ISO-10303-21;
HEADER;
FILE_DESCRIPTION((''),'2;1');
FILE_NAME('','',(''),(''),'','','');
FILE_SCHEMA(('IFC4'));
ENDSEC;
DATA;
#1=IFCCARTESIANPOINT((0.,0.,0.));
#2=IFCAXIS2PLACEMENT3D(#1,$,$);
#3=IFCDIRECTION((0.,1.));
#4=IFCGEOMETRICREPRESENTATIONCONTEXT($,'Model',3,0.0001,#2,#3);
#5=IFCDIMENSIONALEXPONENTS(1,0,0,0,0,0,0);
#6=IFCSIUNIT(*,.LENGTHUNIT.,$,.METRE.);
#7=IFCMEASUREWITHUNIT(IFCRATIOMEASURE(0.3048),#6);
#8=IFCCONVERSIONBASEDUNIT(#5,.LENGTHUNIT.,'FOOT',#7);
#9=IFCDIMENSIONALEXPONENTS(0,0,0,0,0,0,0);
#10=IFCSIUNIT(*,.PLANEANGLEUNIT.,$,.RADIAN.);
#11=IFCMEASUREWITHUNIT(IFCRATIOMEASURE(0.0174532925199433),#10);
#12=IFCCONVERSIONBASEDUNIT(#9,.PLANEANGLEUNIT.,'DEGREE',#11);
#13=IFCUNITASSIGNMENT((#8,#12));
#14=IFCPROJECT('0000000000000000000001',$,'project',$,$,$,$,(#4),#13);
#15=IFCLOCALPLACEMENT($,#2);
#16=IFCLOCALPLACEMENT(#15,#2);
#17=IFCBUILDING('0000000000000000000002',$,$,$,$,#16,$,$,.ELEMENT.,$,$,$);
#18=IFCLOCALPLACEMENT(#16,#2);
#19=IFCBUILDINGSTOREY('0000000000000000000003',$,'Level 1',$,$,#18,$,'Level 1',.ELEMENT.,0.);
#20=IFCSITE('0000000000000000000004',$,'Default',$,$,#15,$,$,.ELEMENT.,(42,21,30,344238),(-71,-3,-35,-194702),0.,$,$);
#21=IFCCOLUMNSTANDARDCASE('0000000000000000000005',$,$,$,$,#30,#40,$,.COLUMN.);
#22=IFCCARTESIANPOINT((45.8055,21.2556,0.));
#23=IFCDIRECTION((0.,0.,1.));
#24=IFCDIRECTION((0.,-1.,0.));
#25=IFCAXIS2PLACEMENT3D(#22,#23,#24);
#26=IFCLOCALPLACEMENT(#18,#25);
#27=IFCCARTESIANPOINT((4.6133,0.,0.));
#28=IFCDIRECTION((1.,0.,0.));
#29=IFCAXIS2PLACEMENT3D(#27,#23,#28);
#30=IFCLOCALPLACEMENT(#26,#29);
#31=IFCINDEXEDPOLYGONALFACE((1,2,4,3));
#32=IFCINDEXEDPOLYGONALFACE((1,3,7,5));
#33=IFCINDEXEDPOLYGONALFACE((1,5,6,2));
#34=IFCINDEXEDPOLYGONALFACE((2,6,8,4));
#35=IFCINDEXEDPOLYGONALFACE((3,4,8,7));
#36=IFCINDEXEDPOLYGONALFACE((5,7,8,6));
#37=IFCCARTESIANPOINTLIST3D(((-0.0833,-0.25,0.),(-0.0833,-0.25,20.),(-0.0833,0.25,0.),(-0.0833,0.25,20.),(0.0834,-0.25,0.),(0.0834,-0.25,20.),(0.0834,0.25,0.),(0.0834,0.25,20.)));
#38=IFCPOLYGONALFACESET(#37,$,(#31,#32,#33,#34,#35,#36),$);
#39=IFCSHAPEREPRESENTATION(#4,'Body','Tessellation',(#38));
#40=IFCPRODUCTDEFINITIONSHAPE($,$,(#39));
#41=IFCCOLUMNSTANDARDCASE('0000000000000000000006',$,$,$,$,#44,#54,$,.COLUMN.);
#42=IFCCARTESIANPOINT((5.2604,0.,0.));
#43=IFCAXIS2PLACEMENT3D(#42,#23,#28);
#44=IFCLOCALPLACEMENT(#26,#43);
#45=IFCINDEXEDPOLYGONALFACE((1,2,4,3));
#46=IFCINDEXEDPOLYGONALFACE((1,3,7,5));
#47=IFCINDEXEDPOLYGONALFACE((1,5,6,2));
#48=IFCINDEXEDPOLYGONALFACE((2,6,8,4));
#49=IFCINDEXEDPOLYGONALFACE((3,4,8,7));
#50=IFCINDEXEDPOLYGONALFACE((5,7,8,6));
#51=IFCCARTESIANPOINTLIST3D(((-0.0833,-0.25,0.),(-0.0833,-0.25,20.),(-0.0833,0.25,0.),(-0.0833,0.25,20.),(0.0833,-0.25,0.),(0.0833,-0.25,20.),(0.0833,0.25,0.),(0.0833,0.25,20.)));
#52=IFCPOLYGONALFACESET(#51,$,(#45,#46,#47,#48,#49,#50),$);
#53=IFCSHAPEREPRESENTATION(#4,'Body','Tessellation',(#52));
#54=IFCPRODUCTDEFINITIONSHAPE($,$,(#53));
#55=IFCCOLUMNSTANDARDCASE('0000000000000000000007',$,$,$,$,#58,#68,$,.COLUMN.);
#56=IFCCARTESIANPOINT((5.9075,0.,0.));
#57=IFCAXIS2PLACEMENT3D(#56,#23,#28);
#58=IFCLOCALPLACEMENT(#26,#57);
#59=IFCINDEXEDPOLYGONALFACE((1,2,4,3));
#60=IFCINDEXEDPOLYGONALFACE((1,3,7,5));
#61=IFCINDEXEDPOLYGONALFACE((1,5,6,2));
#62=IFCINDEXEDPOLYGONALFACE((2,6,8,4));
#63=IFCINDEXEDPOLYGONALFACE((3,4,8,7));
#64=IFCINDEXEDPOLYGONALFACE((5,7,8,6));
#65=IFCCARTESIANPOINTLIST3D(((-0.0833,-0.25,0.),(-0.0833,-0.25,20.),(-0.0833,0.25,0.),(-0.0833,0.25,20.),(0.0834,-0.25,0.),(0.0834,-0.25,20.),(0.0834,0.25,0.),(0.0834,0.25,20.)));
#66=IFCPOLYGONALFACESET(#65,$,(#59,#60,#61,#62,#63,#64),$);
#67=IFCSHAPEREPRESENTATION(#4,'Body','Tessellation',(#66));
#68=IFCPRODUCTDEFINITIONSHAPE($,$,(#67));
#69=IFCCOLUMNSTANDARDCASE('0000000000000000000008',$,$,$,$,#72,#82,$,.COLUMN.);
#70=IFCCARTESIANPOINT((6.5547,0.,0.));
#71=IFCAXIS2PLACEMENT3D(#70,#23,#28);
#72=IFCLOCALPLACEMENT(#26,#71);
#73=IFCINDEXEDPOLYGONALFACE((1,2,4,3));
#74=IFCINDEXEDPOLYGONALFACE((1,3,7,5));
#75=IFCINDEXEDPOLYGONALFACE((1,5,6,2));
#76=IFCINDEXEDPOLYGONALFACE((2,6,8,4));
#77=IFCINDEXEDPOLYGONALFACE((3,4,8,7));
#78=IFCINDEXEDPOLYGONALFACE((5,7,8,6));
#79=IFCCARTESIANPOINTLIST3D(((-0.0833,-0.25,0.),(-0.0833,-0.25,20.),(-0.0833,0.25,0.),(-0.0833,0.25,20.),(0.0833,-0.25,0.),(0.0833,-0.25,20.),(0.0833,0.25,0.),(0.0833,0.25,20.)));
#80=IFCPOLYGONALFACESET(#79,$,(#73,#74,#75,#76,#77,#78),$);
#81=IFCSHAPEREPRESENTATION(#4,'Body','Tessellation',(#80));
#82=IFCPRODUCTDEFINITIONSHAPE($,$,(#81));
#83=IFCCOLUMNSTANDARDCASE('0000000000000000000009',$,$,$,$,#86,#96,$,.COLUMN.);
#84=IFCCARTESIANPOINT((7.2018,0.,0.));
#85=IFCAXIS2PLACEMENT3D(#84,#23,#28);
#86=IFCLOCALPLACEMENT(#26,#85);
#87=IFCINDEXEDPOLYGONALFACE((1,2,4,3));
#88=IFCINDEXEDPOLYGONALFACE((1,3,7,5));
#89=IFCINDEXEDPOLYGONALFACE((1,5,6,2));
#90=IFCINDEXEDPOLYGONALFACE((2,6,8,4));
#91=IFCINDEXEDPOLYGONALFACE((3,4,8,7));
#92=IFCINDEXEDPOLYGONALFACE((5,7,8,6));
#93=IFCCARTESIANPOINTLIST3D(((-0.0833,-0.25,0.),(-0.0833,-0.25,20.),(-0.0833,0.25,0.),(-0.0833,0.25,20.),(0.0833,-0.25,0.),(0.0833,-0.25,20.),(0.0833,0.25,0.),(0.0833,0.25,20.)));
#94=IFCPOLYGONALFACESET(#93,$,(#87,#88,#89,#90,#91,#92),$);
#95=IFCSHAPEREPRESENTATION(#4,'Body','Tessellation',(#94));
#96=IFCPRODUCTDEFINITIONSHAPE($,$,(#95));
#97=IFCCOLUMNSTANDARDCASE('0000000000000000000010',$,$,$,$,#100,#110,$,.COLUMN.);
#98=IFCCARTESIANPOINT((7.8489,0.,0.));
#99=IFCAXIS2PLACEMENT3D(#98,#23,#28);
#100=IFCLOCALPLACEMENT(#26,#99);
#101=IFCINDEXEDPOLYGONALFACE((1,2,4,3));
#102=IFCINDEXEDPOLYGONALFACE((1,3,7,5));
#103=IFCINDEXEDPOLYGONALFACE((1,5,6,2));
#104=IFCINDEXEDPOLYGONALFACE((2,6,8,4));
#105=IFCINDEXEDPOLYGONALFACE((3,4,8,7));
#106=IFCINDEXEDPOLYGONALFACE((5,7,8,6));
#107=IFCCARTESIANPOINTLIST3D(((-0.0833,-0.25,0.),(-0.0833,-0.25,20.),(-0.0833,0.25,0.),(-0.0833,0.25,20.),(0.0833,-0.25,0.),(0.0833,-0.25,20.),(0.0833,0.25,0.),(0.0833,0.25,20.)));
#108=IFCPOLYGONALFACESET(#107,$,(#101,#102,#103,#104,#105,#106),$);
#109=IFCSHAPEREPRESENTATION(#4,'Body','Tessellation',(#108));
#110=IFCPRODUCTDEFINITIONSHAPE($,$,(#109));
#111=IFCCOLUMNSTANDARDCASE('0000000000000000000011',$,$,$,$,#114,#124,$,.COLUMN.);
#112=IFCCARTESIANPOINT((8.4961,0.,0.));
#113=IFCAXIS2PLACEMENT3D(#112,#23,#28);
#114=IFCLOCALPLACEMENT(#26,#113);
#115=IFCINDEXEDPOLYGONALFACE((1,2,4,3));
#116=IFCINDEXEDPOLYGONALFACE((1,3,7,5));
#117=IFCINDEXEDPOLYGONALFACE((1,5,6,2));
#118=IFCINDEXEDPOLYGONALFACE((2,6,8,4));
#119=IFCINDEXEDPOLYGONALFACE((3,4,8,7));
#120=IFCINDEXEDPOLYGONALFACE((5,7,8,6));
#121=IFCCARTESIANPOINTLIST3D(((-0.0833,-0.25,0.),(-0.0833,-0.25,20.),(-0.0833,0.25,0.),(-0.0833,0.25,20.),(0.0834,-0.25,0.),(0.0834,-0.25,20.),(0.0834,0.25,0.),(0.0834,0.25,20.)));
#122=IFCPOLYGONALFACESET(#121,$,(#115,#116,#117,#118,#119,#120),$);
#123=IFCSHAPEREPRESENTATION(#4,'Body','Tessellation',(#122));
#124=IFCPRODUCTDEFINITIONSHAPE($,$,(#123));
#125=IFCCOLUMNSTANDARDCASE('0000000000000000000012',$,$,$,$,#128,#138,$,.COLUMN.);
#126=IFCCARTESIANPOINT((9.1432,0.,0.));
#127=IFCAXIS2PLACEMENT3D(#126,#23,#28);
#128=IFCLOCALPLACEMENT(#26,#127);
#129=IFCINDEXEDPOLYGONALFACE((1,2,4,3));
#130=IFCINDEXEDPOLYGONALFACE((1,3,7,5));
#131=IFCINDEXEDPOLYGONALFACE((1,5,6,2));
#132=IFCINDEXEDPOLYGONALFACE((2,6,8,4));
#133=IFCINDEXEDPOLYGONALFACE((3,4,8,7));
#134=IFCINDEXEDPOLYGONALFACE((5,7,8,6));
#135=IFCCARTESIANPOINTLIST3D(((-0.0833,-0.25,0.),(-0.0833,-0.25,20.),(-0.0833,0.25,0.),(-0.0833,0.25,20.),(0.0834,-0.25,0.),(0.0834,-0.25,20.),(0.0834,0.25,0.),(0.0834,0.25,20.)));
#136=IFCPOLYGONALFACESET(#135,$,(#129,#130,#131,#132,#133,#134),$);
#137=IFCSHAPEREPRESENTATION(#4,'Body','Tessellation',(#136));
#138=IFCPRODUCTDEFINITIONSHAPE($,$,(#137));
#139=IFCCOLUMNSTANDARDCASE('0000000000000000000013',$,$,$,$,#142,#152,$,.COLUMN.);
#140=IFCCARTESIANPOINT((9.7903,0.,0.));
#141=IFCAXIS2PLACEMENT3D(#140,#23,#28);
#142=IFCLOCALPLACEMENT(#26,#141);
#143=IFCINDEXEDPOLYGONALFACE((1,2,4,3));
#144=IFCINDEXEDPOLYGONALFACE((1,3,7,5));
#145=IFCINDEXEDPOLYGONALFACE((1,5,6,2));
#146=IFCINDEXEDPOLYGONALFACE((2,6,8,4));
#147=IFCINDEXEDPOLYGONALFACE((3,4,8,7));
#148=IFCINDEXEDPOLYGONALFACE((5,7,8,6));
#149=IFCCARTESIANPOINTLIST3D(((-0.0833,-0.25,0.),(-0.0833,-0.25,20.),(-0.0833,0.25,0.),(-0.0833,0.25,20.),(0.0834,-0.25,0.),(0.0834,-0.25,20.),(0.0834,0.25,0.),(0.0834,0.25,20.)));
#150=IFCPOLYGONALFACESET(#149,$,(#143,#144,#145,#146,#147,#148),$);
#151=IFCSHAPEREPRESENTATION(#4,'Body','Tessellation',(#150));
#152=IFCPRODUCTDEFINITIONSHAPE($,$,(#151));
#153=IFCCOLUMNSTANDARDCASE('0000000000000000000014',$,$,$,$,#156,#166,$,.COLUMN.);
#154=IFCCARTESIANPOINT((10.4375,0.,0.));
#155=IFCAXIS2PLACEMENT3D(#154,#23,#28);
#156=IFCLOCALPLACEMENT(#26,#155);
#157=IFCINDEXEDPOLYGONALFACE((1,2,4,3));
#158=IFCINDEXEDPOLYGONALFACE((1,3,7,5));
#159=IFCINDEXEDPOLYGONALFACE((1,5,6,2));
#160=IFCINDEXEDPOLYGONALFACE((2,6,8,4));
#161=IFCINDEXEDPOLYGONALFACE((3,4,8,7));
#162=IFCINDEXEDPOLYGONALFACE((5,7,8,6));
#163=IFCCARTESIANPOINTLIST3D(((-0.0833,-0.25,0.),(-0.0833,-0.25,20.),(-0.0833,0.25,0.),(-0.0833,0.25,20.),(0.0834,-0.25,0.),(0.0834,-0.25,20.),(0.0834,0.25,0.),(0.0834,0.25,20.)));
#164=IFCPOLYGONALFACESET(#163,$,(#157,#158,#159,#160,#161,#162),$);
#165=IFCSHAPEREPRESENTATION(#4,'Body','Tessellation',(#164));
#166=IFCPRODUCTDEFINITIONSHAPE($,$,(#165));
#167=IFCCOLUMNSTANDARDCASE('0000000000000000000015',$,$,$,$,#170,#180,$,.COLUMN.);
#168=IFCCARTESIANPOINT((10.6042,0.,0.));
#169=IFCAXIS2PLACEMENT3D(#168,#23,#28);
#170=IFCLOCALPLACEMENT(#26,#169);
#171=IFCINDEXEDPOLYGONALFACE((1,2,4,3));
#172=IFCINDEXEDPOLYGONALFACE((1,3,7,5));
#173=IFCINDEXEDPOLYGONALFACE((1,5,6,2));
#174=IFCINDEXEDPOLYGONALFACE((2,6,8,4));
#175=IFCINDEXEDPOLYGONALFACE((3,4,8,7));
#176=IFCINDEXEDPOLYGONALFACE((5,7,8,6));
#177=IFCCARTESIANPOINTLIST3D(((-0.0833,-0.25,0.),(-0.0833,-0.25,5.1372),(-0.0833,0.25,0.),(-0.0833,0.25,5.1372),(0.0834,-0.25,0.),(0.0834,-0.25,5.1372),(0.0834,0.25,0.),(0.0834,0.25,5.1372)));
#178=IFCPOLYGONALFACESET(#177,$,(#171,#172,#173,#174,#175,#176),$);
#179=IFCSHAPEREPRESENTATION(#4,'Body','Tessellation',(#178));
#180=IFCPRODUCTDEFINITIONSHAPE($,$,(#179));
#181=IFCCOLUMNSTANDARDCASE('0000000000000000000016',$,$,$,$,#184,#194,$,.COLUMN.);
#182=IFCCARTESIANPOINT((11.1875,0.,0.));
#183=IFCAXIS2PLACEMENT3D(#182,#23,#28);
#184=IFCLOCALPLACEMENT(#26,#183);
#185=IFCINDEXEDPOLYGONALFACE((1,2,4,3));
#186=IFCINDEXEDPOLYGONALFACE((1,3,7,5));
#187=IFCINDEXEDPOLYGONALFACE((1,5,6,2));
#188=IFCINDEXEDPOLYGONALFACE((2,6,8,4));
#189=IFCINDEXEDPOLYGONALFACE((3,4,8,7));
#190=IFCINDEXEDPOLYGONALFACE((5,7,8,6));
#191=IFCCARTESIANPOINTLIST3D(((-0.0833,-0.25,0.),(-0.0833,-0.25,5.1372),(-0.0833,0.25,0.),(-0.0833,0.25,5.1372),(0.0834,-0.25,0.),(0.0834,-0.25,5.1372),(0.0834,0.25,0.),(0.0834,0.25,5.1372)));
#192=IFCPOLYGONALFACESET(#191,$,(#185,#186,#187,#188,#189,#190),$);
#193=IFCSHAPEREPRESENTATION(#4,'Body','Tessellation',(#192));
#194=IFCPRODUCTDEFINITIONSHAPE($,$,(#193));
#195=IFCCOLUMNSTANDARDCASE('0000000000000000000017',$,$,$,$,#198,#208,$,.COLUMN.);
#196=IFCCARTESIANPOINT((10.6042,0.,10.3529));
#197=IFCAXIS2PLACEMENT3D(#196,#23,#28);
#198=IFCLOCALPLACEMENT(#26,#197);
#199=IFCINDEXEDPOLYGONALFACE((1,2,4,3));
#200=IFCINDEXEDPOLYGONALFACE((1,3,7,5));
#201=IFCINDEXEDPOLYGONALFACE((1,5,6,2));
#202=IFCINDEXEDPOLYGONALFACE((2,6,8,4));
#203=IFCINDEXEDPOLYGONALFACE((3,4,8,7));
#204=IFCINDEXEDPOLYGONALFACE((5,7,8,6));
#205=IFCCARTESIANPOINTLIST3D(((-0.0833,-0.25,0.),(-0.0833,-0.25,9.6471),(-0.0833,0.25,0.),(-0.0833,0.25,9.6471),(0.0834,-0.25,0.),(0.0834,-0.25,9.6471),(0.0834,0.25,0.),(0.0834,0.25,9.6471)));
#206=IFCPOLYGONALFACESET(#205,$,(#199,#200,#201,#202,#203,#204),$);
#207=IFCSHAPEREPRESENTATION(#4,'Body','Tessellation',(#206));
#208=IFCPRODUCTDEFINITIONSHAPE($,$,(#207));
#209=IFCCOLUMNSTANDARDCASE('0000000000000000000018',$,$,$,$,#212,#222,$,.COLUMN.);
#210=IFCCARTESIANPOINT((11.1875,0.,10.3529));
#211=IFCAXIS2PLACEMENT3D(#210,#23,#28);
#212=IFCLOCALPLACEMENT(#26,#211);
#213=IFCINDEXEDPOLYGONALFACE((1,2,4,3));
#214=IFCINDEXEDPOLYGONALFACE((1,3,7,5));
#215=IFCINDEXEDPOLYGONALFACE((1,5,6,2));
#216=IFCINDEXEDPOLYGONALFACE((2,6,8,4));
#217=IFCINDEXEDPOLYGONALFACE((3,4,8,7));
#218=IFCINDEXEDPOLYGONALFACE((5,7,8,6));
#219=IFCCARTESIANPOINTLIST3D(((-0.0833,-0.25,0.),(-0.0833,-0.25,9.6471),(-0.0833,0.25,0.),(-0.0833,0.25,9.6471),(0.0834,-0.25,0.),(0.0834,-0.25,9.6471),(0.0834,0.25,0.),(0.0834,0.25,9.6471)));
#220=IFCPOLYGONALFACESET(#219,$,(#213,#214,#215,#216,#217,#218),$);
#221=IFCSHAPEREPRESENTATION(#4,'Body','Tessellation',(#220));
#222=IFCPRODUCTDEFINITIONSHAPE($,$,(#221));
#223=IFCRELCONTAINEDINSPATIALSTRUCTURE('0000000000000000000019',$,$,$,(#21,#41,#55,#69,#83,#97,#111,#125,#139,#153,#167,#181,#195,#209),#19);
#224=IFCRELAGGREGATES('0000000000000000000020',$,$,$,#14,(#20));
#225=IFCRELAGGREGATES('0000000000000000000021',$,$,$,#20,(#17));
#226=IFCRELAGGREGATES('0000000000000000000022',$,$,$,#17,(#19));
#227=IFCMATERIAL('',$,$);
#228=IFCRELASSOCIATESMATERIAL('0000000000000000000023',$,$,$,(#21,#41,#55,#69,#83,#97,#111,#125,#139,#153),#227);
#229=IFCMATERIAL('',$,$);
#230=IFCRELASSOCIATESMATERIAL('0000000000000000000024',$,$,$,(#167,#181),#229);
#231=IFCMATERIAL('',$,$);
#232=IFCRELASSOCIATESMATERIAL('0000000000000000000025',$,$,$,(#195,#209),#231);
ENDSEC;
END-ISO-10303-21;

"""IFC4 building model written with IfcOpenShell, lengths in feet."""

from ifc_helpers import new_model, entity, si_unit, converted_unit, direction, frame, origin, place, context, project, spatial, rectangle, extrude, material, element, save


model = new_model("IFC4")

# Units and contexts
model_context = context("Model", 3, precision=0.0001, world=origin(), true_north=direction((0.0, 1.0)))
ifc_project = project(units=[converted_unit("LENGTHUNIT", "FOOT", entity("IfcRatioMeasure", 0.3048), si_unit("LENGTHUNIT", "METRE"), dimensions=[1, 0, 0, 0, 0, 0, 0]), converted_unit("PLANEANGLEUNIT", "DEGREE", entity("IfcRatioMeasure", 0.0174532925199433), si_unit("PLANEANGLEUNIT", "RADIAN"), dimensions=[0, 0, 0, 0, 0, 0, 0])], contexts=[model_context])

# Site, building, storey
site_placement = place(None, origin())
site = spatial("IfcSite", under=ifc_project, at=site_placement, Name="Default", CompositionType="ELEMENT", RefLatitude=(42, 21, 30, 344238), RefLongitude=(-71, -3, -35, -194702), RefElevation=0.0)
building_placement = place(site_placement, origin())
building = spatial("IfcBuilding", under=site, at=building_placement, CompositionType="ELEMENT")
storey_placement = place(building_placement, origin())
storey = spatial("IfcBuildingStorey", under=building, at=storey_placement, Name="Level 1", LongName="Level 1", CompositionType="ELEMENT", Elevation=0.0)

# Columns
ifc_material_1 = material(Name="")
placement = place(storey_placement, frame((45.8055, 21.2556, 0.0), z_axis=(0.0, 0.0, 1.0), x_axis=(0.0, -1.0, 0.0)))
for number, where, z_axis, x_axis in (
    (1, (4.6133, 0.0, 0.0), (0.0, 0.0, 1.0), (1.0, 0.0, 0.0)),
    (2, (5.2604, 0.0, 0.0), (0.0, 0.0, 1.0), (1.0, 0.0, 0.0)),
    (3, (5.9075, 0.0, 0.0), (0.0, 0.0, 1.0), (1.0, 0.0, 0.0)),
    (4, (6.5547, 0.0, 0.0), (0.0, 0.0, 1.0), (1.0, 0.0, 0.0)),
    (5, (7.2018, 0.0, 0.0), (0.0, 0.0, 1.0), (1.0, 0.0, 0.0)),
    (6, (7.8489, 0.0, 0.0), (0.0, 0.0, 1.0), (1.0, 0.0, 0.0)),
    (7, (8.4961, 0.0, 0.0), (0.0, 0.0, 1.0), (1.0, 0.0, 0.0)),
    (8, (9.1432, 0.0, 0.0), (0.0, 0.0, 1.0), (1.0, 0.0, 0.0)),
    (9, (9.7903, 0.0, 0.0), (0.0, 0.0, 1.0), (1.0, 0.0, 0.0)),
    (10, (10.4375, 0.0, 0.0), (0.0, 0.0, 1.0), (1.0, 0.0, 0.0)),
):
    element("IfcColumnStandardCase", number, at=place(placement, frame(where, z_axis=z_axis, x_axis=x_axis)), inside=storey, material=ifc_material_1, PredefinedType="COLUMN", context=model_context, shape_type="SweptSolid", body=[
        extrude(rectangle(XDim=0.1667, YDim=0.5), origin(), (0.0, 0.0, 1.0), 20.0),
    ])
ifc_material_2 = material(Name="")
for number, where, z_axis, x_axis in (
    (11, (10.6042, 0.0, 0.0), (0.0, 0.0, 1.0), (1.0, 0.0, 0.0)),
    (12, (11.1875, 0.0, 0.0), (0.0, 0.0, 1.0), (1.0, 0.0, 0.0)),
):
    element("IfcColumnStandardCase", number, at=place(placement, frame(where, z_axis=z_axis, x_axis=x_axis)), inside=storey, material=ifc_material_2, PredefinedType="COLUMN", context=model_context, shape_type="SweptSolid", body=[
        extrude(rectangle(XDim=0.1667, YDim=0.5), origin(), (0.0, 0.0, 1.0), 5.1372),
    ])
ifc_material_3 = material(Name="")
for number, where, z_axis, x_axis in (
    (13, (10.6042, 0.0, 10.3529), (0.0, 0.0, 1.0), (1.0, 0.0, 0.0)),
    (14, (11.1875, 0.0, 10.3529), (0.0, 0.0, 1.0), (1.0, 0.0, 0.0)),
):
    element("IfcColumnStandardCase", number, at=place(placement, frame(where, z_axis=z_axis, x_axis=x_axis)), inside=storey, material=ifc_material_3, PredefinedType="COLUMN", context=model_context, shape_type="SweptSolid", body=[
        extrude(rectangle(XDim=0.1667, YDim=0.5), origin(), (0.0, 0.0, 1.0), 9.6471),
    ])

save(model, "model.ifc")
